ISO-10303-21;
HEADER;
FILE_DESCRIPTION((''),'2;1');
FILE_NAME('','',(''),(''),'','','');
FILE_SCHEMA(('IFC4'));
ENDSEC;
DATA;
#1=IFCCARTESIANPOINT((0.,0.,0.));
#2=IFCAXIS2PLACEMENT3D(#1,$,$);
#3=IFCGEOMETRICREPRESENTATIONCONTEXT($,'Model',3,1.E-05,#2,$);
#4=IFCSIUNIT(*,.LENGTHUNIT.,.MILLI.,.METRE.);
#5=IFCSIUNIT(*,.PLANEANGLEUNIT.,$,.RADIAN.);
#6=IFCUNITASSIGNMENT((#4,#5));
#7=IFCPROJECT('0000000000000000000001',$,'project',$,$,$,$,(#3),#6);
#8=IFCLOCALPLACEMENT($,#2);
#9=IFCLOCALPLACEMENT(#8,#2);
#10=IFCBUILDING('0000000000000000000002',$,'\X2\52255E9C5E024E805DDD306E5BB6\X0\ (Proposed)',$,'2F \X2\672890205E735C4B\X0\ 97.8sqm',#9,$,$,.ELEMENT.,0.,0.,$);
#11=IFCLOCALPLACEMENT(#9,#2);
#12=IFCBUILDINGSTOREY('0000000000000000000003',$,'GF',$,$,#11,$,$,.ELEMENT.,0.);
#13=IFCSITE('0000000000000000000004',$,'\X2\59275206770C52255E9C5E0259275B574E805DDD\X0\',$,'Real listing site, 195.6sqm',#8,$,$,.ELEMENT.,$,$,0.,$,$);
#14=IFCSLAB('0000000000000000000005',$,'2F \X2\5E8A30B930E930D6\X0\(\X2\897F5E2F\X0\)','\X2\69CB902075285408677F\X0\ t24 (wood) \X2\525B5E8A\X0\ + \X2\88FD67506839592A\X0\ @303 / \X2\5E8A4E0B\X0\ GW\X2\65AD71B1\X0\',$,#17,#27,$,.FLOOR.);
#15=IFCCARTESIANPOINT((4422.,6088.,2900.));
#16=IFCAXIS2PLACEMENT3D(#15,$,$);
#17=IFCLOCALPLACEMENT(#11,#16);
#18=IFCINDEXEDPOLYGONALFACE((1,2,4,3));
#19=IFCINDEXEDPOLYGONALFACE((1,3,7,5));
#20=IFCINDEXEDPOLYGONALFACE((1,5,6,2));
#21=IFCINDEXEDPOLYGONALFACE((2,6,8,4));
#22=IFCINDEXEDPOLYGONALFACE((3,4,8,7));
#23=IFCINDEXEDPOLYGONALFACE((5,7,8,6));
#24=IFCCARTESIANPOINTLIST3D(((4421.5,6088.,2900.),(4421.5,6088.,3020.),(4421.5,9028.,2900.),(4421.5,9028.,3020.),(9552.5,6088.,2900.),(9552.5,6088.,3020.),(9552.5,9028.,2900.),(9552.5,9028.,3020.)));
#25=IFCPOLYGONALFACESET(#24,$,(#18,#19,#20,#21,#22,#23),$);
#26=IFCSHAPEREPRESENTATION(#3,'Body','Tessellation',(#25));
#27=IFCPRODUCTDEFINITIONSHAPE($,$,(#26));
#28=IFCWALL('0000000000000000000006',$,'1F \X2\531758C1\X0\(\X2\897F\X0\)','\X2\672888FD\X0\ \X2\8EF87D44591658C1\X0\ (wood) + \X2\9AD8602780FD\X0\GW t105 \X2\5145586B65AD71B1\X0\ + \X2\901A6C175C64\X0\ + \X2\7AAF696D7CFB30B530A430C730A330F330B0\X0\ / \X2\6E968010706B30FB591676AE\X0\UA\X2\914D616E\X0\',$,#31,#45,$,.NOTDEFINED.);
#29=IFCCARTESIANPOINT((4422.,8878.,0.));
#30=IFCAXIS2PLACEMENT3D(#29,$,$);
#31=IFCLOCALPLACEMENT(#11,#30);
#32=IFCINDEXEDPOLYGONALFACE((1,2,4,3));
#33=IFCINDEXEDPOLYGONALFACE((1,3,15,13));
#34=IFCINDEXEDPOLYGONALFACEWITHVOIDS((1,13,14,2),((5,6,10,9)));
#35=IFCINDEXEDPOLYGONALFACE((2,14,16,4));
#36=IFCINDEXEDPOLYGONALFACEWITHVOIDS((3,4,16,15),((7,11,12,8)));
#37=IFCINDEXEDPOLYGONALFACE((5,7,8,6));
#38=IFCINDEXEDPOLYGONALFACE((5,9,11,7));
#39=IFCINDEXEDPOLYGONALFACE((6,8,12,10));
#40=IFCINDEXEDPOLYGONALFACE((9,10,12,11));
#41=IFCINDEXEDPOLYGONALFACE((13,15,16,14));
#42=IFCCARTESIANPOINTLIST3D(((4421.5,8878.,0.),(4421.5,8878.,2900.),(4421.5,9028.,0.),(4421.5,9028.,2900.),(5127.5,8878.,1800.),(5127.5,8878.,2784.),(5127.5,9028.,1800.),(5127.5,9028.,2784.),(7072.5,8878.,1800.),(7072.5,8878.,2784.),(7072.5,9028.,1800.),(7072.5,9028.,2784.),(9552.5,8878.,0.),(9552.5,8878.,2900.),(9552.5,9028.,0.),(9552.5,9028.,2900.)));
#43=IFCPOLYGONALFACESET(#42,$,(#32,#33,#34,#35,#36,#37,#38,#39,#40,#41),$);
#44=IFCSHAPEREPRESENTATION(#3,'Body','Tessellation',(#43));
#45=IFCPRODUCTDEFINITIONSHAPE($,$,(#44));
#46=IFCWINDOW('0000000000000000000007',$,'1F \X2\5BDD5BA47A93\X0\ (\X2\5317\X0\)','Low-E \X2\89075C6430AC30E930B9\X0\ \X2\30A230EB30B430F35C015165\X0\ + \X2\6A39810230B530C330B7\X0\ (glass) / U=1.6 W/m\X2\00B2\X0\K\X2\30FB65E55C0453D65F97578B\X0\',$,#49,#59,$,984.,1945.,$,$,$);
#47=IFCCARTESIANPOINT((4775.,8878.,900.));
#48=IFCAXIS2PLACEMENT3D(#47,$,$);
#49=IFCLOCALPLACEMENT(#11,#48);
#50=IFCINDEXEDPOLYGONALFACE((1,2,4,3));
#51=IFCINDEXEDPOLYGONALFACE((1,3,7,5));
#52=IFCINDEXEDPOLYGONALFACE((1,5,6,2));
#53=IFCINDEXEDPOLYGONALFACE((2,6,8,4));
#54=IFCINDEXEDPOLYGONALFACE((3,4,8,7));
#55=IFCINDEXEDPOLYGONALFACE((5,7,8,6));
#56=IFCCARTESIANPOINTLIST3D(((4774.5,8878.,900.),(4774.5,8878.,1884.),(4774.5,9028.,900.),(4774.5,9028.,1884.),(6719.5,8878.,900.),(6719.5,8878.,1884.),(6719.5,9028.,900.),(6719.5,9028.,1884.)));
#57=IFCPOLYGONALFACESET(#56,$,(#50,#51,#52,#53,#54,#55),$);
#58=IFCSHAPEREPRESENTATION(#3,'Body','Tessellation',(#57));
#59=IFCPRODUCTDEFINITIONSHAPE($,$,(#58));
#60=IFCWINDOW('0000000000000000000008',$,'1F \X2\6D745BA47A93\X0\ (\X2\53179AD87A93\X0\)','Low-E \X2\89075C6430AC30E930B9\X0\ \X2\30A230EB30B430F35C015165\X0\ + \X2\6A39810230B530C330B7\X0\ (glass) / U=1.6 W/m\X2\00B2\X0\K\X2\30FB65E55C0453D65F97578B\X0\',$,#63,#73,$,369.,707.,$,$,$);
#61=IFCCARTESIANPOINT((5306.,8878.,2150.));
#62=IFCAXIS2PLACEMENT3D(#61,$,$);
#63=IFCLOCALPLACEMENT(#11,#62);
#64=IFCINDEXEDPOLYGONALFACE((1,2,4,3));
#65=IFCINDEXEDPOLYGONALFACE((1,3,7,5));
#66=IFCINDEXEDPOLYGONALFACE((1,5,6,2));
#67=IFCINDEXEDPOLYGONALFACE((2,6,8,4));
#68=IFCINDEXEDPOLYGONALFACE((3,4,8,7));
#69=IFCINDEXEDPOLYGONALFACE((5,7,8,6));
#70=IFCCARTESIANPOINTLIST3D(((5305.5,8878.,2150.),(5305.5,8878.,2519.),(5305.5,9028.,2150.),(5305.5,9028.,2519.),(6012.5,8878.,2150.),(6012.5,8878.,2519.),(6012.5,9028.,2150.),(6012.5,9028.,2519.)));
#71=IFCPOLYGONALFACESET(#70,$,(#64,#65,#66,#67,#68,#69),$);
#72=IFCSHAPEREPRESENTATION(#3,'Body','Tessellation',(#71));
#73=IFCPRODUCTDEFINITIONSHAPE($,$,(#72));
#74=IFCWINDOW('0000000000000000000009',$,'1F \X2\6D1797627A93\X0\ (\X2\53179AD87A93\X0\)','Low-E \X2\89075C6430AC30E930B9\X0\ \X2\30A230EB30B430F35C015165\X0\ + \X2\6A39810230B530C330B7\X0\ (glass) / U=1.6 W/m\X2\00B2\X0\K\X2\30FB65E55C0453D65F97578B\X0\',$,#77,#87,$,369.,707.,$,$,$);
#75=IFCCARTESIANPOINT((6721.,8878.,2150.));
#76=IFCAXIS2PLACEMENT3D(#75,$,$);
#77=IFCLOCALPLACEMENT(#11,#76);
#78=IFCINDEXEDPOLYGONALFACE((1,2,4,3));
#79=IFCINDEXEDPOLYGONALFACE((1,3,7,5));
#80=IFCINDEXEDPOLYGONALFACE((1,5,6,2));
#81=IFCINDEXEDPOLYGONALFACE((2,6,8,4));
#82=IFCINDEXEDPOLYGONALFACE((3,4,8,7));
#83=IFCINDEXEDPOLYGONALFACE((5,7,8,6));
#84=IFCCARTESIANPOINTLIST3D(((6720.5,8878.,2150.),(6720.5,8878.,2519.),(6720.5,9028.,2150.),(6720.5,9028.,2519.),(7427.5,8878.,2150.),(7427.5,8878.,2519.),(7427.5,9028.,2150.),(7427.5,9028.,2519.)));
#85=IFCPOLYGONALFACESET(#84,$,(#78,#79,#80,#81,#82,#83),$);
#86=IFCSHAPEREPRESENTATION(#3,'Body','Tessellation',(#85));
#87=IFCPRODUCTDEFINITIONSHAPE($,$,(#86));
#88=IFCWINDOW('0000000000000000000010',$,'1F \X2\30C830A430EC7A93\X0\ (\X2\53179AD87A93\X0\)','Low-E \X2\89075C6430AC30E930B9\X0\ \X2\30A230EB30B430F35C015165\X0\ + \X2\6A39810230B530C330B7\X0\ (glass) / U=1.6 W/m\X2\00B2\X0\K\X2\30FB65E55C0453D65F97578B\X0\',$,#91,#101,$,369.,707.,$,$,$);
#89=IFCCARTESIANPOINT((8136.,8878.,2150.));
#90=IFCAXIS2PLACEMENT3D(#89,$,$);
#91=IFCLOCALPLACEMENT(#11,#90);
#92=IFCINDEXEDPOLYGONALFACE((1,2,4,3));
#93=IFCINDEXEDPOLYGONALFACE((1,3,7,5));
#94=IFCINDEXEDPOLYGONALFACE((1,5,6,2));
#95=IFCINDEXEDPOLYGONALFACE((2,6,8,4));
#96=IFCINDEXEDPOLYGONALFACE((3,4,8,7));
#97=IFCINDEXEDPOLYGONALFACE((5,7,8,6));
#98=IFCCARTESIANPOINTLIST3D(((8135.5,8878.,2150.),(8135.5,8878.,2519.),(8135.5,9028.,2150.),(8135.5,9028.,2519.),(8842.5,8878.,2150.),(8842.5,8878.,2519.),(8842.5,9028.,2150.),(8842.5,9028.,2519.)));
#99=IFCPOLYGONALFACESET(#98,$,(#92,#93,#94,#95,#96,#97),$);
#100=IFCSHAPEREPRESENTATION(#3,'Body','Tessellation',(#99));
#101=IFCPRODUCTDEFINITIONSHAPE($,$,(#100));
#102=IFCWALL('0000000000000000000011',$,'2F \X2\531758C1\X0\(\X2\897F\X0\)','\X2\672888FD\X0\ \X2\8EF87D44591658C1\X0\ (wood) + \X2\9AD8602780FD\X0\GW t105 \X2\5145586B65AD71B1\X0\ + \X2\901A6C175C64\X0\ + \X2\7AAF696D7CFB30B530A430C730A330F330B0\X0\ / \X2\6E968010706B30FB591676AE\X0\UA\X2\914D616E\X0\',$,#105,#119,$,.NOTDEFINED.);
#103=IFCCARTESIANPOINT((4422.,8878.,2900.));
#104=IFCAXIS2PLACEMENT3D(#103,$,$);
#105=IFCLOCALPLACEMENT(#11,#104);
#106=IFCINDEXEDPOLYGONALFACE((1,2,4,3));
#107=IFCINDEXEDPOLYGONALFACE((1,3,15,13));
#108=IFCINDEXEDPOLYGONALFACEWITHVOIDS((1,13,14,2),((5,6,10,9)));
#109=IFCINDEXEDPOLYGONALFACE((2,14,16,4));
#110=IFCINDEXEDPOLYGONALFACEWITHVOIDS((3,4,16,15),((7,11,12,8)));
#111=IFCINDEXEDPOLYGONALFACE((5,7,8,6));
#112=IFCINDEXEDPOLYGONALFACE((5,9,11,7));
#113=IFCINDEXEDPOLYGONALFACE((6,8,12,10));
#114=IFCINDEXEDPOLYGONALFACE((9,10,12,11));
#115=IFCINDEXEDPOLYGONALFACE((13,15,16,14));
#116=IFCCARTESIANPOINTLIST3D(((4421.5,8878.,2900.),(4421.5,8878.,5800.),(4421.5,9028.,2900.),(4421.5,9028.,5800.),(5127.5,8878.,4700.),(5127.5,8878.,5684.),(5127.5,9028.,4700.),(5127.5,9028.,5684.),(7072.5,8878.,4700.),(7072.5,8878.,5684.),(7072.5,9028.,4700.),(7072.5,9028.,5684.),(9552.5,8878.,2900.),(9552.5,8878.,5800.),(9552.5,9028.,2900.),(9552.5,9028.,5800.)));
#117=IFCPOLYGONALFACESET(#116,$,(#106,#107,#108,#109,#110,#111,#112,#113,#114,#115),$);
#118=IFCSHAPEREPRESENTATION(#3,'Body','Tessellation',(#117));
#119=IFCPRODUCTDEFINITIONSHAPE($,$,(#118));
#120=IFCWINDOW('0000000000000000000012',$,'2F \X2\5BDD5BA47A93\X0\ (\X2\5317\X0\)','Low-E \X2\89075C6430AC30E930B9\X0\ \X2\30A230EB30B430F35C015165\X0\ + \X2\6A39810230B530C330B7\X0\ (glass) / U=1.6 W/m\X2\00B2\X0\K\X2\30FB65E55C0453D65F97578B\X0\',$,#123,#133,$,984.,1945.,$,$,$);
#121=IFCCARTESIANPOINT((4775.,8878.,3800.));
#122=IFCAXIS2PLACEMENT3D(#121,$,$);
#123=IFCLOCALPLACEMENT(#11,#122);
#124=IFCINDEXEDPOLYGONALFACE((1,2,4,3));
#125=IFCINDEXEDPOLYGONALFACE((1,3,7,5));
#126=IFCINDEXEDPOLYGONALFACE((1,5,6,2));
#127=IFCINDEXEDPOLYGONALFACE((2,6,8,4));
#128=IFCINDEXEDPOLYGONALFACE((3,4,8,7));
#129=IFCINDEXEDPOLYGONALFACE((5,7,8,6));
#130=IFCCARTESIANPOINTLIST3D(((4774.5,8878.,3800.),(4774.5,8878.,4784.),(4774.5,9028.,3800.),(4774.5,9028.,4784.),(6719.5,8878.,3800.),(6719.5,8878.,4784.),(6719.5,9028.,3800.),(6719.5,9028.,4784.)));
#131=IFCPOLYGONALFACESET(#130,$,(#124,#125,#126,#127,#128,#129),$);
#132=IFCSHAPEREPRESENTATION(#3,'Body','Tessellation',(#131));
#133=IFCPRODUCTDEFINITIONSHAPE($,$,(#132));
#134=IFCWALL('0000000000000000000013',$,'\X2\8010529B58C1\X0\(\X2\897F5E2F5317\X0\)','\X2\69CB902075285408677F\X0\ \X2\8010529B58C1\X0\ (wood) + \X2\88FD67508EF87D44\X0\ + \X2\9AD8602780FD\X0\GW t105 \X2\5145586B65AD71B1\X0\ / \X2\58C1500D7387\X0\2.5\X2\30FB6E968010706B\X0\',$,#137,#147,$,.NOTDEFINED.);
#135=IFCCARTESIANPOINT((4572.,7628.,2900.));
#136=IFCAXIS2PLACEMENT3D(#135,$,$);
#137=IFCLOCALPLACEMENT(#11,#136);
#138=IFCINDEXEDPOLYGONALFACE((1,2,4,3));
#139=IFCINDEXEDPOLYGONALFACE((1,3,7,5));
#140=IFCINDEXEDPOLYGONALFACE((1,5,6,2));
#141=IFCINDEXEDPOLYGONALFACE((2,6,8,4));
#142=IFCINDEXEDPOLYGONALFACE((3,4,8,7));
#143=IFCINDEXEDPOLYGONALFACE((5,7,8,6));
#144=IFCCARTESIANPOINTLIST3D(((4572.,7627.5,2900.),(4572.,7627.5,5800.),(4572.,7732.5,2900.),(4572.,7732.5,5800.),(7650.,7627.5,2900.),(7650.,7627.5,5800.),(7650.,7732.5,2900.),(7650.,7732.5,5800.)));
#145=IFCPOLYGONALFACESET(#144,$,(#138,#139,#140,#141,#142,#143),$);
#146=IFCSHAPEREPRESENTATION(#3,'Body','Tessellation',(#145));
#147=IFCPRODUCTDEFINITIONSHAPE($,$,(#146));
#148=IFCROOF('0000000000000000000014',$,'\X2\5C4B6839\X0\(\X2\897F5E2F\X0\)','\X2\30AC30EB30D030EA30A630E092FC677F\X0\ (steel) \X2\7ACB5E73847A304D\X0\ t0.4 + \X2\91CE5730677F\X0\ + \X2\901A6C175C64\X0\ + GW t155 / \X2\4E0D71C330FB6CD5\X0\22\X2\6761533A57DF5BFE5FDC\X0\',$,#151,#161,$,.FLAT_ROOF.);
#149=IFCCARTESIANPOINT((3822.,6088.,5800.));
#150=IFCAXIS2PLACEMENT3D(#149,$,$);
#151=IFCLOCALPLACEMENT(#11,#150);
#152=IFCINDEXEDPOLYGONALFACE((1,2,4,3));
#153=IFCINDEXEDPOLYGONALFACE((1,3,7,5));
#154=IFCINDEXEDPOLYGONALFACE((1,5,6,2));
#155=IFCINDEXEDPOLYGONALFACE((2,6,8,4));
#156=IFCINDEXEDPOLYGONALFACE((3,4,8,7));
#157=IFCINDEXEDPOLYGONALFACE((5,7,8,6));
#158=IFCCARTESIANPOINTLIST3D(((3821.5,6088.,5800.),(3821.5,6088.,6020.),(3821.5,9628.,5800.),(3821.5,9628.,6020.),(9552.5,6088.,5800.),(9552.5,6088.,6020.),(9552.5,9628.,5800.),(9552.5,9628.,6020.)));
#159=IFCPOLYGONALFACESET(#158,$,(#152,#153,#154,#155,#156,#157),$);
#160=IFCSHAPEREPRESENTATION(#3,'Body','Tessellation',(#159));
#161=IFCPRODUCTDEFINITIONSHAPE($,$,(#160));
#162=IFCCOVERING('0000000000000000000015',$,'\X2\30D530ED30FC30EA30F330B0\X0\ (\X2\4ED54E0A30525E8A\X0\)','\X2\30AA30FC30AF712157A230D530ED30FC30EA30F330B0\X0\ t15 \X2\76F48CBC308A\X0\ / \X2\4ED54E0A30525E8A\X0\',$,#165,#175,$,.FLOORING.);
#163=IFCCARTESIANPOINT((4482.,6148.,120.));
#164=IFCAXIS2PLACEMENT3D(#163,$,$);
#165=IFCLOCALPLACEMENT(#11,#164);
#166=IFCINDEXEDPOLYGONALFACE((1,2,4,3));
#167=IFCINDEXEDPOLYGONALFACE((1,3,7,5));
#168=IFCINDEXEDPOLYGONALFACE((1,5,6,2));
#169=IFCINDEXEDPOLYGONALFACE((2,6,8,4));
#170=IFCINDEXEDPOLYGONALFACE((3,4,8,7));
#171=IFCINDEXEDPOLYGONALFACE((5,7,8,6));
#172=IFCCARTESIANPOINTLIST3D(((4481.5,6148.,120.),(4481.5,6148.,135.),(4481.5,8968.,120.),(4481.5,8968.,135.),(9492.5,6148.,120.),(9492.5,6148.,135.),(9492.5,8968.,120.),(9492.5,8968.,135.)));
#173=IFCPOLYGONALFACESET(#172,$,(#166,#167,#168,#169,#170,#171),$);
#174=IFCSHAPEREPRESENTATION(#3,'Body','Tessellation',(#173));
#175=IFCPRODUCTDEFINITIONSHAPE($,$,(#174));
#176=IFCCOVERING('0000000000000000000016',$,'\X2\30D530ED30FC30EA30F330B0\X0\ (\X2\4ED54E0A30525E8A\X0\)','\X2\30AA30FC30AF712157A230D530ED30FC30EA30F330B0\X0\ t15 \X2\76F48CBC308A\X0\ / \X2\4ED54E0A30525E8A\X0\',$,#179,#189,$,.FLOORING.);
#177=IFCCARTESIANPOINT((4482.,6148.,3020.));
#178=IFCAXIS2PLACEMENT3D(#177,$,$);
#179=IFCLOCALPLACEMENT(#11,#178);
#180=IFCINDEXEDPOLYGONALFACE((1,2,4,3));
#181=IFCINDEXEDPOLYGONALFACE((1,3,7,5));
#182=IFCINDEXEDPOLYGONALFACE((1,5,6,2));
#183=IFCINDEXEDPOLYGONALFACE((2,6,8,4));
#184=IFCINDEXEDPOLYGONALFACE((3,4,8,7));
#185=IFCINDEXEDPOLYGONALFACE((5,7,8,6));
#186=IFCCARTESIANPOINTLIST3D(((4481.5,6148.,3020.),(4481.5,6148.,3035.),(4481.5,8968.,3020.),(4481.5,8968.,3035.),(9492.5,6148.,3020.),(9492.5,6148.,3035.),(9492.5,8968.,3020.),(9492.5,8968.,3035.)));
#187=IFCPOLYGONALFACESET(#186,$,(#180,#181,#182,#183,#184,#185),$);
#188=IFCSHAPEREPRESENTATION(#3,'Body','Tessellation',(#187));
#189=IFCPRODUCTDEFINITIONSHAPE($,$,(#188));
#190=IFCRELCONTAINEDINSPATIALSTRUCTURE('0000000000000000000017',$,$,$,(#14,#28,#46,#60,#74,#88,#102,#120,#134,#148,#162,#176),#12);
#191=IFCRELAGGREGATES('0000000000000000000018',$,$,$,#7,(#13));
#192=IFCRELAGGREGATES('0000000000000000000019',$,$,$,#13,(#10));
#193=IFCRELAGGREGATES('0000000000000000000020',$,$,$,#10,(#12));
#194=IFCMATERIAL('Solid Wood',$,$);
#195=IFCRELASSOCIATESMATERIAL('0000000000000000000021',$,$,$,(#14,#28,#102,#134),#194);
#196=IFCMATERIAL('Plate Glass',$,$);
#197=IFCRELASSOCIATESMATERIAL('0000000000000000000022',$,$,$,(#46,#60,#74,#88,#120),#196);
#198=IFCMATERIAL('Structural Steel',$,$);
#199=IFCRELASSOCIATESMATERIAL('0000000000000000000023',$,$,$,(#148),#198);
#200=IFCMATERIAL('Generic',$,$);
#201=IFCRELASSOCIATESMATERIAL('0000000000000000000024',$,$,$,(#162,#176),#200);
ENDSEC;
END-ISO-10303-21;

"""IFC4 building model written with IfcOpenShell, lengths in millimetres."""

from ifc_helpers import new_model, si_unit, frame, frame_2d, origin, place, context, project, spatial, rectangle, extrude, material, element, fill, save


model = new_model("IFC4")

# Units and contexts
model_context = context("Model", 3, precision=1e-05, world=origin())
ifc_project = project(units=[si_unit("LENGTHUNIT", "METRE", prefix="MILLI"), si_unit("PLANEANGLEUNIT", "RADIAN")], contexts=[model_context])

# Site, building, storey
site_placement = place(None, origin())
site = spatial("IfcSite", under=ifc_project, at=site_placement, Name="大分県別府市大字亀川", ObjectType="Real listing site, 195.6sqm", CompositionType="ELEMENT", RefElevation=0.0)
building_placement = place(site_placement, origin())
building = spatial("IfcBuilding", under=site, at=building_placement, Name="別府市亀川の家 (Proposed)", ObjectType="2F 木造平屋 97.8sqm", CompositionType="ELEMENT", ElevationOfRefHeight=0.0, ElevationOfTerrain=0.0)
storey_placement = place(building_placement, origin())
storey = spatial("IfcBuildingStorey", under=building, at=storey_placement, Name="GF", CompositionType="ELEMENT", Elevation=0.0)

# Slab
ifc_material_1 = material(Name="Solid Wood")
slab_1_placement = place(storey_placement, frame((4422.0, 6088.0, 2900.0)))
element("IfcSlab", 1, at=slab_1_placement, inside=storey, material=ifc_material_1, Name="2F 床スラブ(西帯)", Description="構造用合板 t24 (wood) 剛床 + 製材根太 @303 / 床下 GW断熱", PredefinedType="FLOOR", context=model_context, shape_type="SweptSolid", body=[
    extrude(rectangle(XDim=5131.0, YDim=2940.0, at=frame_2d((2565.0, 1470.0))), frame((4422.0, 6088.0, 2900.0)), (0.0, 0.0, 1.0), 120.0),
])

# Wall, openings, windows
wall_1_placement = place(storey_placement, frame((4422.0, 8878.0, 0.0)))
wall_1 = element("IfcWall", 2, at=wall_1_placement, inside=storey, material=ifc_material_1, Name="1F 北壁(西)", Description="木製 軸組外壁 (wood) + 高性能GW t105 充填断熱 + 通気層 + 窯業系サイディング / 準耐火・外皮UA配慮", PredefinedType="NOTDEFINED", context=model_context, shape_type="SweptSolid", body=[
    extrude(rectangle(XDim=5131.0, YDim=150.0, at=frame_2d((2565.0, 75.0))), frame((4422.0, 8878.0, 0.0)), (0.0, 0.0, 1.0), 2900.0),
])
opening_1_placement = place(storey_placement, frame((4775.0, 8878.0, 900.0)))
opening_1 = element("IfcOpeningElement", 3, at=opening_1_placement, cuts=wall_1, PredefinedType="NOTDEFINED", context=model_context, shape_type="SweptSolid", body=[
    extrude(rectangle(XDim=1945.0, YDim=150.0, at=frame_2d((972.0, 75.0))), frame((4775.0, 8878.0, 900.0)), (0.0, 0.0, 1.0), 984.0),
])
opening_2_placement = place(storey_placement, frame((5306.0, 8878.0, 2150.0)))
opening_2 = element("IfcOpeningElement", 4, at=opening_2_placement, cuts=wall_1, PredefinedType="NOTDEFINED", context=model_context, shape_type="SweptSolid", body=[
    extrude(rectangle(XDim=707.0, YDim=150.0, at=frame_2d((353.0, 75.0))), frame((5306.0, 8878.0, 2150.0)), (0.0, 0.0, 1.0), 369.0),
])
opening_3_placement = place(storey_placement, frame((6721.0, 8878.0, 2150.0)))
opening_3 = element("IfcOpeningElement", 5, at=opening_3_placement, cuts=wall_1, PredefinedType="NOTDEFINED", context=model_context, shape_type="SweptSolid", body=[
    extrude(rectangle(XDim=707.0, YDim=150.0, at=frame_2d((353.0, 75.0))), frame((6721.0, 8878.0, 2150.0)), (0.0, 0.0, 1.0), 369.0),
])
opening_4_placement = place(storey_placement, frame((8136.0, 8878.0, 2150.0)))
opening_4 = element("IfcOpeningElement", 6, at=opening_4_placement, cuts=wall_1, PredefinedType="NOTDEFINED", context=model_context, shape_type="SweptSolid", body=[
    extrude(rectangle(XDim=707.0, YDim=150.0, at=frame_2d((353.0, 75.0))), frame((8136.0, 8878.0, 2150.0)), (0.0, 0.0, 1.0), 369.0),
])
ifc_material_2 = material(Name="Plate Glass")
window_1_placement = place(storey_placement, frame((4775.0, 8878.0, 900.0)))
window_1 = element("IfcWindow", 7, at=window_1_placement, inside=storey, material=ifc_material_2, Name="1F 寝室窓 (北)", Description="Low-E 複層ガラス アルゴン封入 + 樹脂サッシ (glass) / U=1.6 W/m²K・日射取得型", OverallHeight=984.0, OverallWidth=1945.0, context=model_context, shape_type="SweptSolid", body=[
    extrude(rectangle(XDim=1945.0, YDim=150.0, at=frame_2d((972.0, 75.0))), frame((4775.0, 8878.0, 900.0)), (0.0, 0.0, 1.0), 984.0),
])
fill(opening_1, window_1)
window_2_placement = place(storey_placement, frame((5306.0, 8878.0, 2150.0)))
window_2 = element("IfcWindow", 8, at=window_2_placement, inside=storey, material=ifc_material_2, Name="1F 浴室窓 (北高窓)", Description="Low-E 複層ガラス アルゴン封入 + 樹脂サッシ (glass) / U=1.6 W/m²K・日射取得型", OverallHeight=369.0, OverallWidth=707.0, context=model_context, shape_type="SweptSolid", body=[
    extrude(rectangle(XDim=707.0, YDim=150.0, at=frame_2d((353.0, 75.0))), frame((5306.0, 8878.0, 2150.0)), (0.0, 0.0, 1.0), 369.0),
])
fill(opening_2, window_2)
window_3_placement = place(storey_placement, frame((6721.0, 8878.0, 2150.0)))
window_3 = element("IfcWindow", 9, at=window_3_placement, inside=storey, material=ifc_material_2, Name="1F 洗面窓 (北高窓)", Description="Low-E 複層ガラス アルゴン封入 + 樹脂サッシ (glass) / U=1.6 W/m²K・日射取得型", OverallHeight=369.0, OverallWidth=707.0, context=model_context, shape_type="SweptSolid", body=[
    extrude(rectangle(XDim=707.0, YDim=150.0, at=frame_2d((353.0, 75.0))), frame((6721.0, 8878.0, 2150.0)), (0.0, 0.0, 1.0), 369.0),
])
fill(opening_3, window_3)
window_4_placement = place(storey_placement, frame((8136.0, 8878.0, 2150.0)))
window_4 = element("IfcWindow", 10, at=window_4_placement, inside=storey, material=ifc_material_2, Name="1F トイレ窓 (北高窓)", Description="Low-E 複層ガラス アルゴン封入 + 樹脂サッシ (glass) / U=1.6 W/m²K・日射取得型", OverallHeight=369.0, OverallWidth=707.0, context=model_context, shape_type="SweptSolid", body=[
    extrude(rectangle(XDim=707.0, YDim=150.0, at=frame_2d((353.0, 75.0))), frame((8136.0, 8878.0, 2150.0)), (0.0, 0.0, 1.0), 369.0),
])
fill(opening_4, window_4)

# Wall, opening, window
wall_2_placement = place(storey_placement, frame((4422.0, 8878.0, 2900.0)))
wall_2 = element("IfcWall", 11, at=wall_2_placement, inside=storey, material=ifc_material_1, Name="2F 北壁(西)", Description="木製 軸組外壁 (wood) + 高性能GW t105 充填断熱 + 通気層 + 窯業系サイディング / 準耐火・外皮UA配慮", PredefinedType="NOTDEFINED", context=model_context, shape_type="SweptSolid", body=[
    extrude(rectangle(XDim=5131.0, YDim=150.0, at=frame_2d((2565.0, 75.0))), frame((4422.0, 8878.0, 2900.0)), (0.0, 0.0, 1.0), 2900.0),
])
opening_5_placement = place(storey_placement, frame((4775.0, 8878.0, 3800.0)))
opening_5 = element("IfcOpeningElement", 12, at=opening_5_placement, cuts=wall_2, PredefinedType="NOTDEFINED", context=model_context, shape_type="SweptSolid", body=[
    extrude(rectangle(XDim=1945.0, YDim=150.0, at=frame_2d((972.0, 75.0))), frame((4775.0, 8878.0, 3800.0)), (0.0, 0.0, 1.0), 984.0),
])
window_5_placement = place(storey_placement, frame((4775.0, 8878.0, 3800.0)))
window_5 = element("IfcWindow", 13, at=window_5_placement, inside=storey, material=ifc_material_2, Name="2F 寝室窓 (北)", Description="Low-E 複層ガラス アルゴン封入 + 樹脂サッシ (glass) / U=1.6 W/m²K・日射取得型", OverallHeight=984.0, OverallWidth=1945.0, context=model_context, shape_type="SweptSolid", body=[
    extrude(rectangle(XDim=1945.0, YDim=150.0, at=frame_2d((972.0, 75.0))), frame((4775.0, 8878.0, 3800.0)), (0.0, 0.0, 1.0), 984.0),
])
fill(opening_5, window_5)

# Wall
wall_3_placement = place(storey_placement, frame((4572.0, 7628.0, 2900.0)))
element("IfcWall", 14, at=wall_3_placement, inside=storey, material=ifc_material_1, Name="耐力壁(西帯北)", Description="構造用合板 耐力壁 (wood) + 製材軸組 + 高性能GW t105 充填断熱 / 壁倍率2.5・準耐火", PredefinedType="NOTDEFINED", context=model_context, shape_type="SweptSolid", body=[
    extrude(rectangle(XDim=3078.0, YDim=105.0, at=frame_2d((1539.0, 52.0))), frame((4572.0, 7628.0, 2900.0)), (0.0, 0.0, 1.0), 2900.0),
])

# Roof
ifc_material_3 = material(Name="Structural Steel")
for number, where, name in (
    (15, (3822.0, 6088.0, 5800.0), "屋根(西帯)"),
):
    element("IfcRoof", number, at=place(storey_placement, frame(where)), inside=storey, material=ifc_material_3, Name=name, Description="ガルバリウム鋼板 (steel) 立平葺き t0.4 + 野地板 + 通気層 + GW t155 / 不燃・法22条区域対応", PredefinedType="FLAT_ROOF", context=model_context, shape_type="SweptSolid", body=[
        extrude(rectangle(XDim=5731.0, YDim=3540.0, at=frame_2d((2865.0, 1770.0))), frame((3822.0, 6088.0, 5800.0)), (0.0, 0.0, 1.0), 220.0),
    ])

# Coverings
ifc_material_4 = material(Name="Generic")
covering_1_placement = place(storey_placement, frame((4482.0, 6148.0, 120.0)))
element("IfcCovering", 16, at=covering_1_placement, inside=storey, material=ifc_material_4, Name="フローリング (仕上げ床)", Description="オーク無垢フローリング t15 直貼り / 仕上げ床", PredefinedType="FLOORING", context=model_context, shape_type="SweptSolid", body=[
    extrude(rectangle(XDim=5011.0, YDim=2820.0, at=frame_2d((2505.0, 1410.0))), frame((4482.0, 6148.0, 120.0)), (0.0, 0.0, 1.0), 15.0),
])
covering_2_placement = place(storey_placement, frame((4482.0, 6148.0, 3020.0)))
element("IfcCovering", 17, at=covering_2_placement, inside=storey, material=ifc_material_4, Name="フローリング (仕上げ床)", Description="オーク無垢フローリング t15 直貼り / 仕上げ床", PredefinedType="FLOORING", context=model_context, shape_type="SweptSolid", body=[
    extrude(rectangle(XDim=5011.0, YDim=2820.0, at=frame_2d((2505.0, 1410.0))), frame((4482.0, 6148.0, 3020.0)), (0.0, 0.0, 1.0), 15.0),
])

save(model, "model.ifc")
